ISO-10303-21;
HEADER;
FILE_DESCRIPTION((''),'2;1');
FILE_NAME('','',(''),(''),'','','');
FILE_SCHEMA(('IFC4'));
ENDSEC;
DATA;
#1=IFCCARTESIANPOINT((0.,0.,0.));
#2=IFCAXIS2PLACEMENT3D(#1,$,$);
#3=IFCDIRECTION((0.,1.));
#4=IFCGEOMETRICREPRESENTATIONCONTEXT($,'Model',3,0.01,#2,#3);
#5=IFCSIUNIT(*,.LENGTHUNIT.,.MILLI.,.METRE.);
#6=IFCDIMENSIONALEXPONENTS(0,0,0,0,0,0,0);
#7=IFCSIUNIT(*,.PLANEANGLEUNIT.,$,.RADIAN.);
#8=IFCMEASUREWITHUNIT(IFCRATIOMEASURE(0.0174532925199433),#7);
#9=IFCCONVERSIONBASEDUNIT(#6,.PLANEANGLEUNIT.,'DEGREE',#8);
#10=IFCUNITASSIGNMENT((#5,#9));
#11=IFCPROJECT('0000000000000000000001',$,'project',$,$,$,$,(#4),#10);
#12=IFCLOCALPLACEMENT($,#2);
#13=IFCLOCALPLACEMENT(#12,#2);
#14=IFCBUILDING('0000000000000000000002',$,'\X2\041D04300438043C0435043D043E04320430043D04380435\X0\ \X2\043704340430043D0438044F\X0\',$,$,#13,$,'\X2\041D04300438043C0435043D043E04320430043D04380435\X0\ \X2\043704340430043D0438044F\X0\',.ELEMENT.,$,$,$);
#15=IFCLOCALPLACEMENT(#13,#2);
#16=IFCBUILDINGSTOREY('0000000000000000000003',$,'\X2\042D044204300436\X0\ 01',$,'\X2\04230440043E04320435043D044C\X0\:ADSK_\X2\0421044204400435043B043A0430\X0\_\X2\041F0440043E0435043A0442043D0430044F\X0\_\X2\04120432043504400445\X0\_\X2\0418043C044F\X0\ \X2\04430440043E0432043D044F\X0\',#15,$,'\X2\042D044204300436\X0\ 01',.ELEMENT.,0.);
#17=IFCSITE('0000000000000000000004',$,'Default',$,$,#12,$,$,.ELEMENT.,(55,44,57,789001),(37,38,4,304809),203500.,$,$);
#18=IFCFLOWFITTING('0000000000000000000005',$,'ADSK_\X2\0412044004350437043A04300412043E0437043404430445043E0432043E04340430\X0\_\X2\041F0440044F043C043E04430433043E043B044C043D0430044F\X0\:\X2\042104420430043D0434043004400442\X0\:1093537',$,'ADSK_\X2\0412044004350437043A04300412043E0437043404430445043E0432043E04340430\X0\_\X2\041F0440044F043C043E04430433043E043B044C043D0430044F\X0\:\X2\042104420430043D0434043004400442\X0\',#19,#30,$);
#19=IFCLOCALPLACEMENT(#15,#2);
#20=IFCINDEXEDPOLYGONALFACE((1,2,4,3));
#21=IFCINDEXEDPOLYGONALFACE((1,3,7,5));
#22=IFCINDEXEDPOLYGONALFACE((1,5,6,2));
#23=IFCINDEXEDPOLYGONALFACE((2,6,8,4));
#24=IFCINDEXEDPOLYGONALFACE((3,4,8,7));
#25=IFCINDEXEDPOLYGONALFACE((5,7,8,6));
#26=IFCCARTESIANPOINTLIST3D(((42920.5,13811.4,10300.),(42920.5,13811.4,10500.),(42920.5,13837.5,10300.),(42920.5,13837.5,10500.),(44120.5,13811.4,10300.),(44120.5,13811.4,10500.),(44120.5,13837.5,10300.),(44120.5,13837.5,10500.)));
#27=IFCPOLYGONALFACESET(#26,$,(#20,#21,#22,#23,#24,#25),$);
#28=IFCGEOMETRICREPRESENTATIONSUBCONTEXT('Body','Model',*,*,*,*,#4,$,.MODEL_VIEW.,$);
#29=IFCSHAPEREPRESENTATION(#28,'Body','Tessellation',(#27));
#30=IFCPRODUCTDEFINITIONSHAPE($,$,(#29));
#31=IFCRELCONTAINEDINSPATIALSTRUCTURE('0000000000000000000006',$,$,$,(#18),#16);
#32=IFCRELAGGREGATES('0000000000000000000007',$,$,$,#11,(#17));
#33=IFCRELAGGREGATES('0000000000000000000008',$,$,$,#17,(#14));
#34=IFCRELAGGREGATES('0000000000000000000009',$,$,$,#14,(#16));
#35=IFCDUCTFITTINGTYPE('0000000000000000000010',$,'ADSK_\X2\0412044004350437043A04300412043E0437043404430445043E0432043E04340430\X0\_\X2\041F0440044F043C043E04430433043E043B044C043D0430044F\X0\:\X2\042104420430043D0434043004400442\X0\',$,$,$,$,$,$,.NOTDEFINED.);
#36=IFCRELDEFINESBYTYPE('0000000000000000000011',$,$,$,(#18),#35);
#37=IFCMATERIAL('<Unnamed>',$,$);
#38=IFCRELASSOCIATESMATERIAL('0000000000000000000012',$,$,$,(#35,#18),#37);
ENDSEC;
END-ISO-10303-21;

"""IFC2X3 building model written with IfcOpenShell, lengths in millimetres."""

from ifc_helpers import new_model, entity, si_unit, converted_unit, direction, frame, origin, origin_2d_with_axis, place, context, subcontext, project, spatial, rectangle, extrude, source, transform, mapped, material, type_object, type_shapes, element, save


model = new_model("IFC2X3")

# Units and contexts
model_context = context("Model", 3, precision=0.01, world=origin(), true_north=direction((0.0, 1.0)))
body_context = subcontext(model_context, "Body", "Model", "MODEL_VIEW")
ifc_project = project(units=[si_unit("LENGTHUNIT", "METRE", prefix="MILLI"), converted_unit("PLANEANGLEUNIT", "DEGREE", entity("IfcRatioMeasure", 0.0174532925199433), si_unit("PLANEANGLEUNIT", "RADIAN"), dimensions=[0, 0, 0, 0, 0, 0, 0])], contexts=[model_context])

# Site, building, storey
site_placement = place(None, origin())
site = spatial("IfcSite", under=ifc_project, at=site_placement, Name="Default", CompositionType="ELEMENT", RefLatitude=(55, 44, 57, 789001), RefLongitude=(37, 38, 4, 304809), RefElevation=203500.0)
building_placement = place(site_placement, origin())
building = spatial("IfcBuilding", under=site, at=building_placement, Name="Наименование здания", LongName="Наименование здания", CompositionType="ELEMENT")
storey_placement = place(building_placement, origin())
storey = spatial("IfcBuildingStorey", under=building, at=storey_placement, Name="Этаж 01", ObjectType="Уровень:ADSK_Стрелка_Проектная_Вверх_Имя уровня", LongName="Этаж 01", CompositionType="ELEMENT", Elevation=0.0)

# Shared definitions
ifc_material_1 = material(Name="<Unnamed>")

# Flow fitting
duct_fitting_type_1 = type_object("IfcDuctFittingType", Name="ADSK_ВрезкаВоздуховода_Прямоугольная:Стандарт", PredefinedType="NOTDEFINED", material=ifc_material_1)
shared_shape_1 = source(origin(), body_context, "Body", "SweptSolid", [
    extrude(rectangle(XDim=26.1, YDim=1200.0, at=origin_2d_with_axis()), frame((7.0, 0.0, -100.0)), (0.0, 0.0, 1.0), 200.0),
])
type_shapes(duct_fitting_type_1, [shared_shape_1])
flow_fitting_1_placement = place(storey_placement, frame((43520.5, 13817.5, 10400.0), z_axis=(0.0, 0.0, -1.0), x_axis=(0.0, 1.0, 0.0)))
element("IfcFlowFitting", 1, at=flow_fitting_1_placement, inside=storey, type_object=duct_fitting_type_1, material=ifc_material_1, Name="ADSK_ВрезкаВоздуховода_Прямоугольная:Стандарт:1093537", ObjectType="ADSK_ВрезкаВоздуховода_Прямоугольная:Стандарт", context=body_context, shape_type="MappedRepresentation", body=[
    mapped(shared_shape_1, transform((0.0, 0.0, 0.0), scale=1.0)),
])

save(model, "model.ifc")
